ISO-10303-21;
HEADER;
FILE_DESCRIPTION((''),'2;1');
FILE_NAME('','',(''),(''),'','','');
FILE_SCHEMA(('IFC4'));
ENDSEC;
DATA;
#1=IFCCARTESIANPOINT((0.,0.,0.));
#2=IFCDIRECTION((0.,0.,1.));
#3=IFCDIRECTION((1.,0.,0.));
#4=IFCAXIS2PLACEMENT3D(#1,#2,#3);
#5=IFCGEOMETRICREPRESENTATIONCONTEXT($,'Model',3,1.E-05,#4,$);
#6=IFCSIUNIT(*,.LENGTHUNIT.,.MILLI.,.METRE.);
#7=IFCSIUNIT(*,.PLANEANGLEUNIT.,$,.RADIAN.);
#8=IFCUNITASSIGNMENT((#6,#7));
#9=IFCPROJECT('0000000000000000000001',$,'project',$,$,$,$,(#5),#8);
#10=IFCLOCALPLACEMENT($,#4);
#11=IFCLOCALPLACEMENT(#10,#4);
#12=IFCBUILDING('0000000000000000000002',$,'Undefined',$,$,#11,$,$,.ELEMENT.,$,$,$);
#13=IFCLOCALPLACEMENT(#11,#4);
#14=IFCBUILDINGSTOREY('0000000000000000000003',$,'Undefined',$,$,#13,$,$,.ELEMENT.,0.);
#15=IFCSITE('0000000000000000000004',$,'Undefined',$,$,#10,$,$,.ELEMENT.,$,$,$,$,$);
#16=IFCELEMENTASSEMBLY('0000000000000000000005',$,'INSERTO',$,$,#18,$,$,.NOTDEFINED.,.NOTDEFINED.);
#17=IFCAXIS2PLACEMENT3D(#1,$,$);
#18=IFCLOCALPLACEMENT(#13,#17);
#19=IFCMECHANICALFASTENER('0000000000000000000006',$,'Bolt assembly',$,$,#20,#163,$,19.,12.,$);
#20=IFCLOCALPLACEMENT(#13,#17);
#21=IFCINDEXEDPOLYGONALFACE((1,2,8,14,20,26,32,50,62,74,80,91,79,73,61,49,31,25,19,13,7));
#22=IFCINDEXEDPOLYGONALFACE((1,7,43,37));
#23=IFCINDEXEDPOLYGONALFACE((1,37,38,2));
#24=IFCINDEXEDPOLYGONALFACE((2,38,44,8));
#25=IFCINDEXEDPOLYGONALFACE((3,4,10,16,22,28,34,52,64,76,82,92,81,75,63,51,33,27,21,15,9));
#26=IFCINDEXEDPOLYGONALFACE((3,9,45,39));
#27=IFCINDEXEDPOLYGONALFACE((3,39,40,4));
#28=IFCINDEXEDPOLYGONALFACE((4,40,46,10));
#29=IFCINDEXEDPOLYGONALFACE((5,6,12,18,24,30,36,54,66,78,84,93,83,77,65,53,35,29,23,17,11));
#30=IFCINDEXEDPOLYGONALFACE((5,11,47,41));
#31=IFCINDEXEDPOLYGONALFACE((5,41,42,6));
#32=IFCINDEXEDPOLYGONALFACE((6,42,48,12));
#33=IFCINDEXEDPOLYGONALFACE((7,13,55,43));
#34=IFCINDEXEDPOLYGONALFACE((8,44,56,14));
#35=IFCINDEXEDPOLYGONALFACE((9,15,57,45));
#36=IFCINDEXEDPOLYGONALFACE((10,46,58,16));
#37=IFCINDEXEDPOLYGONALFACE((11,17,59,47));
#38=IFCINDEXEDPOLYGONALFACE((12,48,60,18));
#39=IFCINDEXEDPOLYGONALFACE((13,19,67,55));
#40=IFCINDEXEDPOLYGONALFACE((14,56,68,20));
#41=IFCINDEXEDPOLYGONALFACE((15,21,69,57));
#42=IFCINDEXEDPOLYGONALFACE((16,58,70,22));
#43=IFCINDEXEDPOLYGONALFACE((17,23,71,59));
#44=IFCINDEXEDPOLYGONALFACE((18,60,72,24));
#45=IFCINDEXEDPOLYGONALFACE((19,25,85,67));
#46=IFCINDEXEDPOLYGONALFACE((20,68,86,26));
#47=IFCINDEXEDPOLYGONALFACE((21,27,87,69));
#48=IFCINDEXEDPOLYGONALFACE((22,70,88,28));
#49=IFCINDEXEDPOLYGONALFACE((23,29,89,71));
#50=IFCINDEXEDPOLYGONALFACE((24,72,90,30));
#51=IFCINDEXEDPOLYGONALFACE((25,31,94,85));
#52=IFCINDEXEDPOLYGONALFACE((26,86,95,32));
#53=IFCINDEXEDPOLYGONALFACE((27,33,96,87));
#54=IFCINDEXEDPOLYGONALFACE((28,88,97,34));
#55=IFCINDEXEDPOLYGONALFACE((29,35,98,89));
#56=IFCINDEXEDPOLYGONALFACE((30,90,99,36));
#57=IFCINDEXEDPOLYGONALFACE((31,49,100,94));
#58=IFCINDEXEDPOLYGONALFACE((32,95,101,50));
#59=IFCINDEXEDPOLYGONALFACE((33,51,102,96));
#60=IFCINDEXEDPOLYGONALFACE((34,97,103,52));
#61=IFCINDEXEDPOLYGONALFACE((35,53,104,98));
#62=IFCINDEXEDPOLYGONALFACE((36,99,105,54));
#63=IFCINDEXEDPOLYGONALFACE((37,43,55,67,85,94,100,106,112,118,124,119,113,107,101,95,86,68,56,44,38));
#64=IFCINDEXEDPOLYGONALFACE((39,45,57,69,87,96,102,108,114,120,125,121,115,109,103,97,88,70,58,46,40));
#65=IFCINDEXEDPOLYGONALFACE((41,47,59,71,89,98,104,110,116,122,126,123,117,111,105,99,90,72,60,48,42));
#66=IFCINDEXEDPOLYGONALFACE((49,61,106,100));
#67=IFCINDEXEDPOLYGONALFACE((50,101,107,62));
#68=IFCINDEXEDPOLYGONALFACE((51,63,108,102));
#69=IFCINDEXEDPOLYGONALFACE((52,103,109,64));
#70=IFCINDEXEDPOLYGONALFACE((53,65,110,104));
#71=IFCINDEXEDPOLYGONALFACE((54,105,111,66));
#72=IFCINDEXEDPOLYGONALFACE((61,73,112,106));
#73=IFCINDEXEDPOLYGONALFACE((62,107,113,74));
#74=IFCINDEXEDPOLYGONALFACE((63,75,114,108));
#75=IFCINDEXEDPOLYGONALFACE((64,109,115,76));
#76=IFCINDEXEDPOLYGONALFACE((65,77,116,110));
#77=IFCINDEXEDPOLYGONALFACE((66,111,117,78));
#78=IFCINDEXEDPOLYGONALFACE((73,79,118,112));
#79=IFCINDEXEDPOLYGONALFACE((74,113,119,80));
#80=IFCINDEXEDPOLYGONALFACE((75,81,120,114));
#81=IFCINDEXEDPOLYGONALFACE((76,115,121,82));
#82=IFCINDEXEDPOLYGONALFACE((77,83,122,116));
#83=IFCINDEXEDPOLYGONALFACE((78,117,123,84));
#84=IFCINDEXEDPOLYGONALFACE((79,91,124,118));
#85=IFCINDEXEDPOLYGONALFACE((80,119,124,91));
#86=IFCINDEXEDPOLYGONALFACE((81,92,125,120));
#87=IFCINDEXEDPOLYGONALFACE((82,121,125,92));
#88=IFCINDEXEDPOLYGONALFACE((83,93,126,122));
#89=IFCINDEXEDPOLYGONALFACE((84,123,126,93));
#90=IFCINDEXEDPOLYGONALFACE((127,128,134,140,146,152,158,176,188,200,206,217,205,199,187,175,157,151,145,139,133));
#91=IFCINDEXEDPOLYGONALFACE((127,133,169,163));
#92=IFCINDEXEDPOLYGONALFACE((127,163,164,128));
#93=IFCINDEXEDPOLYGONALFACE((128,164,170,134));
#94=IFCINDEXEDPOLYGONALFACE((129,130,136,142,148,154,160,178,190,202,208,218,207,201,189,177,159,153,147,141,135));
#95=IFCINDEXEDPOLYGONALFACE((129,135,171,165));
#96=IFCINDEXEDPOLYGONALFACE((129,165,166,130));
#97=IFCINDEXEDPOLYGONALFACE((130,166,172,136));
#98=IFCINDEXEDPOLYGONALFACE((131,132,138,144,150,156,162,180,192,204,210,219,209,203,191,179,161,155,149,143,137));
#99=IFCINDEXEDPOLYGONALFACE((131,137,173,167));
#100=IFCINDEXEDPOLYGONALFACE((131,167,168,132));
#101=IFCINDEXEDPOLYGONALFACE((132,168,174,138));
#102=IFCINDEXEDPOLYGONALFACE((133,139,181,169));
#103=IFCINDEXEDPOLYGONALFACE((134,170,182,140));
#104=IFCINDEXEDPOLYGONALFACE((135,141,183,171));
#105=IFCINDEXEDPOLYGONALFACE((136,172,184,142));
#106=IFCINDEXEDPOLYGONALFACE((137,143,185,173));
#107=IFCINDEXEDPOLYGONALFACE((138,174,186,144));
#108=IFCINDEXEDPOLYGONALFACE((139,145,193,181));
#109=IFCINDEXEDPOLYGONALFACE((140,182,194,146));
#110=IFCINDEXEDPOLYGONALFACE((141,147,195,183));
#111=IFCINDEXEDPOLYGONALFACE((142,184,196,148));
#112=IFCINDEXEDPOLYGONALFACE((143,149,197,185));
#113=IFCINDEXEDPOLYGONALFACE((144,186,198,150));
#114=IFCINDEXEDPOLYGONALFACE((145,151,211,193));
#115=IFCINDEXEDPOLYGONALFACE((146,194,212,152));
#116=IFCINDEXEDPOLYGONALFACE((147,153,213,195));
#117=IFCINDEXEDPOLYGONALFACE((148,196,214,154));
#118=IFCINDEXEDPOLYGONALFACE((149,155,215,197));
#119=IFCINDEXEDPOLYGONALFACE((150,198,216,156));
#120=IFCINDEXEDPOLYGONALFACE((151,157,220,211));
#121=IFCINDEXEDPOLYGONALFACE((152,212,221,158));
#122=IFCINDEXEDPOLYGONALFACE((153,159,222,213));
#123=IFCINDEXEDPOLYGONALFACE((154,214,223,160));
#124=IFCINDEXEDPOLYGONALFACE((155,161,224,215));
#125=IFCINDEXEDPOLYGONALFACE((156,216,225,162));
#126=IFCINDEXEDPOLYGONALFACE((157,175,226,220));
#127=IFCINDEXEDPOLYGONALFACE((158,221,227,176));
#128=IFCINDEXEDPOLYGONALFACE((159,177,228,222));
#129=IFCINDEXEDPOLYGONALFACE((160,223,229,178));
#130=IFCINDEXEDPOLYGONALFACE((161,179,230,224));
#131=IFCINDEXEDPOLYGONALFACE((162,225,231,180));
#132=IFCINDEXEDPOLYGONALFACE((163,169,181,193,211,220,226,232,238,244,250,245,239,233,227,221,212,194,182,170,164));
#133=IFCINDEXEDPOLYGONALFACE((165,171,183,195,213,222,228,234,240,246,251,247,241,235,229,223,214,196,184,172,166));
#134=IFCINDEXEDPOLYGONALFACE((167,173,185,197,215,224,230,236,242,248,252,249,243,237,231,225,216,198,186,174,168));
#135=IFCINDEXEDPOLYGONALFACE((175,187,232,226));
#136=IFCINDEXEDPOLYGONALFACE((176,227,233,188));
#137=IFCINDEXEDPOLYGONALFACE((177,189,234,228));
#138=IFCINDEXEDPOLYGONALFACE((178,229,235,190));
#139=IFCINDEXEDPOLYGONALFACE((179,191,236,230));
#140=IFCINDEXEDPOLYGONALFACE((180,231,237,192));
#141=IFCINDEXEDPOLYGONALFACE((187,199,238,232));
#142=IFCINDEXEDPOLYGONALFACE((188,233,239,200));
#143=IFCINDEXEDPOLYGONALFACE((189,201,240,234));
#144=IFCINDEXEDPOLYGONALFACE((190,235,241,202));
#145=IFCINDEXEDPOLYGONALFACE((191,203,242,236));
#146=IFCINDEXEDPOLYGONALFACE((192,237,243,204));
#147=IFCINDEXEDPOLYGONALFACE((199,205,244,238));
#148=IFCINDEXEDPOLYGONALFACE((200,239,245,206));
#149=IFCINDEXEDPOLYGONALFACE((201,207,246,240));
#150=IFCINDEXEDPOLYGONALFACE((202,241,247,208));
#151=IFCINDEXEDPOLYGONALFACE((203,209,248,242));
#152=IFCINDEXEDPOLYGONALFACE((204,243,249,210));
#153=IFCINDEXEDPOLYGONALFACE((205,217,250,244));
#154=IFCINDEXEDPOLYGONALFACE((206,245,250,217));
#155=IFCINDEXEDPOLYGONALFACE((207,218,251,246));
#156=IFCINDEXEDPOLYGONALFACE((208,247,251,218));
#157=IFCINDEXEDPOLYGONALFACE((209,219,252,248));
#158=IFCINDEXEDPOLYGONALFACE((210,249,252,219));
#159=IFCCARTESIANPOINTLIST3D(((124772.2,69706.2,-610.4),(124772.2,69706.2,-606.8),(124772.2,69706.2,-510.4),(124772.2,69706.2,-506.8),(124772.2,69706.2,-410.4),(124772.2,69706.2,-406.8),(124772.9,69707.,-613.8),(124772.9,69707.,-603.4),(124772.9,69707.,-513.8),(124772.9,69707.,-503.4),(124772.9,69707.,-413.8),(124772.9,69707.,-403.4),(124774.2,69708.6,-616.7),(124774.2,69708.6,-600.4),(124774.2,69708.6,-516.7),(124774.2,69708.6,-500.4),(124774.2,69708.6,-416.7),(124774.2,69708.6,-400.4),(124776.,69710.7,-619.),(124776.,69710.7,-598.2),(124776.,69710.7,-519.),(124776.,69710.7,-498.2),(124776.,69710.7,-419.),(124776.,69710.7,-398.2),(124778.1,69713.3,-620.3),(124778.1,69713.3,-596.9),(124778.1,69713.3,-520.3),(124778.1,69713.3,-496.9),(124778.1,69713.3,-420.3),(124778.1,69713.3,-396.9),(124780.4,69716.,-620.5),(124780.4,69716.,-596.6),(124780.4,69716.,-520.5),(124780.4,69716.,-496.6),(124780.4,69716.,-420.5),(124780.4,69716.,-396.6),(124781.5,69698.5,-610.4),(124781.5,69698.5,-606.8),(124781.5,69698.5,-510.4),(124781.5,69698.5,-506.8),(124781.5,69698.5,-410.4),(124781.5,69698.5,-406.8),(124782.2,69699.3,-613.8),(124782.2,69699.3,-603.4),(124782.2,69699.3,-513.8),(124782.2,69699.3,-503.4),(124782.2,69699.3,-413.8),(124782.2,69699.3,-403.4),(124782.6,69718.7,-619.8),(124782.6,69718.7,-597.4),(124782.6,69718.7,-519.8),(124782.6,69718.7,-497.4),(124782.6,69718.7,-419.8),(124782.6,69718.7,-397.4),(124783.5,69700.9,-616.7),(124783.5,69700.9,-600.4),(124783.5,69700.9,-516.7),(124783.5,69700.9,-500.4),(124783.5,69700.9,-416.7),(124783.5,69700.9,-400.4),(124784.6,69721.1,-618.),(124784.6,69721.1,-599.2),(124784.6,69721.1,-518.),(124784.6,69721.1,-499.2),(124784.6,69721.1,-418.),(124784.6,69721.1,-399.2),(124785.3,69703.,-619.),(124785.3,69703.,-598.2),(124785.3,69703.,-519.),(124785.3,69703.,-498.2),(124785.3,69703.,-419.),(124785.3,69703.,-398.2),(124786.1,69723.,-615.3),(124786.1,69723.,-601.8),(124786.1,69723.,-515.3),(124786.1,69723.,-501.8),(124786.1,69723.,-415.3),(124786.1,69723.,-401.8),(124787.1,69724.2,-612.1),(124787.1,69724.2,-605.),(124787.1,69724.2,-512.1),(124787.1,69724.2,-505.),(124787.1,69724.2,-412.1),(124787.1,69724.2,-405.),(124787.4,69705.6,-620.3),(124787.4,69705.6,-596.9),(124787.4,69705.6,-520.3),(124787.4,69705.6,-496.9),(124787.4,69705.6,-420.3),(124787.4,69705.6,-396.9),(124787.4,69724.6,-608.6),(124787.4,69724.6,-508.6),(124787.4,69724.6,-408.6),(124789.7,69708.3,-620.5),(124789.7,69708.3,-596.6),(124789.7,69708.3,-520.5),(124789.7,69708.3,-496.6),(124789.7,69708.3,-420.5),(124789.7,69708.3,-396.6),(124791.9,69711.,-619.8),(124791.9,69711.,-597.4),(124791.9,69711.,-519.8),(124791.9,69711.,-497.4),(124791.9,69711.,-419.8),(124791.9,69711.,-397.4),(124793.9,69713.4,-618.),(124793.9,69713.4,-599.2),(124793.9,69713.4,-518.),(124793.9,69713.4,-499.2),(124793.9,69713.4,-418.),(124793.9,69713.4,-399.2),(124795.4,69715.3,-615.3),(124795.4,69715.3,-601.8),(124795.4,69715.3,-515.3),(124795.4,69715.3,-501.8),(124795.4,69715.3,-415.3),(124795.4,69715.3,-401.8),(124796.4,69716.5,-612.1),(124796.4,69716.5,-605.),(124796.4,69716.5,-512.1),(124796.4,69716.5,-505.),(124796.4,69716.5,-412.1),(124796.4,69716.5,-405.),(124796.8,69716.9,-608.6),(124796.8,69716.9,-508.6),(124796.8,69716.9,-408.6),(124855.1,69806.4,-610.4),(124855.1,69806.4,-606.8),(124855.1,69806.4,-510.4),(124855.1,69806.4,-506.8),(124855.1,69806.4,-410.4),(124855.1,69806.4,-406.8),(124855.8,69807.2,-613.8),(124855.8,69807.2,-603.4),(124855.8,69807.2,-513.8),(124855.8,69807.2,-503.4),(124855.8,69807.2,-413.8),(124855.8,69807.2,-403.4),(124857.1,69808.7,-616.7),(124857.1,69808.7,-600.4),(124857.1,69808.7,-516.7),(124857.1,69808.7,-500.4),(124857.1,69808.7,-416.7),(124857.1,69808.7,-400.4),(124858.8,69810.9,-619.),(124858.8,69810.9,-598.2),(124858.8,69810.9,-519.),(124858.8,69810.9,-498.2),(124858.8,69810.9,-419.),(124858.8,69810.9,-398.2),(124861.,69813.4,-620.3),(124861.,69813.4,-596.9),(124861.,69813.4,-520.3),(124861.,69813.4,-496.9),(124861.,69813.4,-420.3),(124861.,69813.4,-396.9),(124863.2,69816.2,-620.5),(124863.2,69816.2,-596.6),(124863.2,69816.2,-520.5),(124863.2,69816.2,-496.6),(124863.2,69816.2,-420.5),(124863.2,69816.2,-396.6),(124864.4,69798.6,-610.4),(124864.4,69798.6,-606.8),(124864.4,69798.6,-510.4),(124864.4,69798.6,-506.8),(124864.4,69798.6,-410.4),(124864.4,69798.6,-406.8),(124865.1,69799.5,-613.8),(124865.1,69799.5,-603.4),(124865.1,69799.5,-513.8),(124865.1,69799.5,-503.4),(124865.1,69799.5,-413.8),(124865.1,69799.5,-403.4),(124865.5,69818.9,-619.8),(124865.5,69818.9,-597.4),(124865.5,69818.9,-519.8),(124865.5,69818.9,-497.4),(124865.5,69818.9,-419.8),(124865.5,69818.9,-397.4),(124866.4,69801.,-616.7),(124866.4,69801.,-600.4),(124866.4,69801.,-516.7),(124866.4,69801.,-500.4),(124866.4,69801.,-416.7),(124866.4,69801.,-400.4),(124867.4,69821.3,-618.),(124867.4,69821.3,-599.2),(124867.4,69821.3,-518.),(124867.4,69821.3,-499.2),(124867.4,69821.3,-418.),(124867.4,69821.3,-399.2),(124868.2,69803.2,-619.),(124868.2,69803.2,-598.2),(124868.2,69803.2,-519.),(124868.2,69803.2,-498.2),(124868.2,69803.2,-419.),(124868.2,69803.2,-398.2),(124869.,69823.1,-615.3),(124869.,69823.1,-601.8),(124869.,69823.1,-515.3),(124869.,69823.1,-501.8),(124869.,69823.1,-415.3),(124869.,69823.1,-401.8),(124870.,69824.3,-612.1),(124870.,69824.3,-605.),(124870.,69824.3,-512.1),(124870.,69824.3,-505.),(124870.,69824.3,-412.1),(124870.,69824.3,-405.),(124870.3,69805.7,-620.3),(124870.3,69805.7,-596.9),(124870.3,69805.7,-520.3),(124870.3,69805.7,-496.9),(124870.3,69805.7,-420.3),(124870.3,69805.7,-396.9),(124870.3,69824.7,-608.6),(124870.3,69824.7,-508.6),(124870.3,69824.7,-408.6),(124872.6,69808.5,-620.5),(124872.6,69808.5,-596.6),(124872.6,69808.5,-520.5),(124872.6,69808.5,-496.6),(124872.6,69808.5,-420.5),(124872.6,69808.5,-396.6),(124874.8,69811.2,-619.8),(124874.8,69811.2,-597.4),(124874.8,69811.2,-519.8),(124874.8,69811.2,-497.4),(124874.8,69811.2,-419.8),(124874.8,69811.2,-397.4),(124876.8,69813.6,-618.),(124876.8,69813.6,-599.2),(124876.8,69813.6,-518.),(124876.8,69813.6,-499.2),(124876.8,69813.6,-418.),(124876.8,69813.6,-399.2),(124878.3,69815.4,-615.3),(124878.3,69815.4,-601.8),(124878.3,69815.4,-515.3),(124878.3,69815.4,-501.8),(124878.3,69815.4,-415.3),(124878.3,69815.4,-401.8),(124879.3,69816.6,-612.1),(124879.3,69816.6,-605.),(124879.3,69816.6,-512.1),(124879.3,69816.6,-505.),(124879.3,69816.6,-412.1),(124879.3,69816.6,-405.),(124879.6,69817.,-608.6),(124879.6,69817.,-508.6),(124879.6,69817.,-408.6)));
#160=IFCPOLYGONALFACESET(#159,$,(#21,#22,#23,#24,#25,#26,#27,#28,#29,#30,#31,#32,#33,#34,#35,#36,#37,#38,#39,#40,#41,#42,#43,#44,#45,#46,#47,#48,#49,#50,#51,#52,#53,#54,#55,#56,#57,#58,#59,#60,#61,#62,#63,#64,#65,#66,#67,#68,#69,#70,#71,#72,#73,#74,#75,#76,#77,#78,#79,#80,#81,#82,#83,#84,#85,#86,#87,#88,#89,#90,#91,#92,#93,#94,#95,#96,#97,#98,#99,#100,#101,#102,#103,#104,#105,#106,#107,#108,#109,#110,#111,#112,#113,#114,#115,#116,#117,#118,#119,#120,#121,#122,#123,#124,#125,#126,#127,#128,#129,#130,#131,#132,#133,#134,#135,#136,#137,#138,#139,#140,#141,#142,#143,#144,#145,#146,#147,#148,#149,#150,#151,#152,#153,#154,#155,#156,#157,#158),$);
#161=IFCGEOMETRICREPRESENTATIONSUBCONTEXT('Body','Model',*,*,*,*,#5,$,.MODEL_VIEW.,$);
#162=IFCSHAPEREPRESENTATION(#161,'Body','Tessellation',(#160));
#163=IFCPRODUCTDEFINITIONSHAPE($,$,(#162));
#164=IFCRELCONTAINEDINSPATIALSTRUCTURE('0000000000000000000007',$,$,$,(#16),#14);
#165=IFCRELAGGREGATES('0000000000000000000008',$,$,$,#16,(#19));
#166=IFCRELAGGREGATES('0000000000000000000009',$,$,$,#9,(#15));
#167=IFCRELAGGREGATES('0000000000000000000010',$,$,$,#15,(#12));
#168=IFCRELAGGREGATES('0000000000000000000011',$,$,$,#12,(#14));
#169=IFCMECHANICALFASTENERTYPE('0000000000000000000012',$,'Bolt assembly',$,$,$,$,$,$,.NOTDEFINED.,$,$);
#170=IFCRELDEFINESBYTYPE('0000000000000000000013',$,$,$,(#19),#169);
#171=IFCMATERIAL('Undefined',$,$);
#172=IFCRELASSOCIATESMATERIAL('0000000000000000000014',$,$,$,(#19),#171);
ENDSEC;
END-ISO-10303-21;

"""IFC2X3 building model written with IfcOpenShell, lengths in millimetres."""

from ifc_helpers import new_model, si_unit, frame, origin_with_axes, origin_2d_with_axis, place, context, subcontext, project, spatial, circle, extrude, source, transform, mapped, material, type_object, element, aggregate, save


model = new_model("IFC2X3")

# Units and contexts
model_context = context("Model", 3, precision=1e-05, world=origin_with_axes())
body_context = subcontext(model_context, "Body", "Model", "MODEL_VIEW")
ifc_project = project(units=[si_unit("LENGTHUNIT", "METRE", prefix="MILLI"), si_unit("PLANEANGLEUNIT", "RADIAN")], contexts=[model_context])

# Site, building, storey
site_placement = place(None, origin_with_axes())
site = spatial("IfcSite", under=ifc_project, at=site_placement, Name="Undefined", CompositionType="ELEMENT")
building_placement = place(site_placement, origin_with_axes())
building = spatial("IfcBuilding", under=site, at=building_placement, Name="Undefined", CompositionType="ELEMENT")
storey_placement = place(building_placement, origin_with_axes())
storey = spatial("IfcBuildingStorey", under=building, at=storey_placement, Name="Undefined", CompositionType="ELEMENT", Elevation=0.0)

# Element assembly
assembly_1_placement = place(storey_placement, origin_with_axes())
assembly_1 = element("IfcElementAssembly", 1, at=assembly_1_placement, inside=storey, Name="INSERTO", AssemblyPlace="NOTDEFINED", PredefinedType="NOTDEFINED")

# Mechanical fastener
ifc_material_1 = material(Name="Undefined")
mechanical_fastener_type = type_object("IfcMechanicalFastenerType", Name="Bolt assembly")
shared_shape_1 = source(origin_with_axes(), body_context, "Body", "SweptSolid", [
    extrude(circle(Radius=12.0, at=origin_2d_with_axis()), frame((0.0, 0.0, 0.0), z_axis=(0.0, 1.0, 0.0), x_axis=(1.0, 0.0, 0.0)), (0.0, 0.0, 1.0), 12.1),
])
mechanical_fastener_1_placement = place(assembly_1_placement, frame((124789.1, 69707.6, -508.6), z_axis=(0.000001, 0.000001, 1.0), x_axis=(0.637563, 0.770399, -0.000002)))
mechanical_fastener_1 = element("IfcMechanicalFastener", 2, at=mechanical_fastener_1_placement, type_object=mechanical_fastener_type, material=ifc_material_1, Name="Bolt assembly", NominalDiameter=19.0, NominalLength=12.0, context=body_context, shape_type="MappedRepresentation", body=[
    mapped(shared_shape_1, transform((0.0, 0.0, -100.0))),
    mapped(shared_shape_1, transform((130.0, 0.0, -100.0))),
    mapped(shared_shape_1, transform((0.0, 0.0, 0.0))),
    mapped(shared_shape_1, transform((130.0, 0.0, 0.0))),
    mapped(shared_shape_1, transform((0.0, 0.0, 100.0))),
    mapped(shared_shape_1, transform((130.0, 0.0, 100.0))),
])
aggregate(assembly_1, [mechanical_fastener_1])

save(model, "model.ifc")
